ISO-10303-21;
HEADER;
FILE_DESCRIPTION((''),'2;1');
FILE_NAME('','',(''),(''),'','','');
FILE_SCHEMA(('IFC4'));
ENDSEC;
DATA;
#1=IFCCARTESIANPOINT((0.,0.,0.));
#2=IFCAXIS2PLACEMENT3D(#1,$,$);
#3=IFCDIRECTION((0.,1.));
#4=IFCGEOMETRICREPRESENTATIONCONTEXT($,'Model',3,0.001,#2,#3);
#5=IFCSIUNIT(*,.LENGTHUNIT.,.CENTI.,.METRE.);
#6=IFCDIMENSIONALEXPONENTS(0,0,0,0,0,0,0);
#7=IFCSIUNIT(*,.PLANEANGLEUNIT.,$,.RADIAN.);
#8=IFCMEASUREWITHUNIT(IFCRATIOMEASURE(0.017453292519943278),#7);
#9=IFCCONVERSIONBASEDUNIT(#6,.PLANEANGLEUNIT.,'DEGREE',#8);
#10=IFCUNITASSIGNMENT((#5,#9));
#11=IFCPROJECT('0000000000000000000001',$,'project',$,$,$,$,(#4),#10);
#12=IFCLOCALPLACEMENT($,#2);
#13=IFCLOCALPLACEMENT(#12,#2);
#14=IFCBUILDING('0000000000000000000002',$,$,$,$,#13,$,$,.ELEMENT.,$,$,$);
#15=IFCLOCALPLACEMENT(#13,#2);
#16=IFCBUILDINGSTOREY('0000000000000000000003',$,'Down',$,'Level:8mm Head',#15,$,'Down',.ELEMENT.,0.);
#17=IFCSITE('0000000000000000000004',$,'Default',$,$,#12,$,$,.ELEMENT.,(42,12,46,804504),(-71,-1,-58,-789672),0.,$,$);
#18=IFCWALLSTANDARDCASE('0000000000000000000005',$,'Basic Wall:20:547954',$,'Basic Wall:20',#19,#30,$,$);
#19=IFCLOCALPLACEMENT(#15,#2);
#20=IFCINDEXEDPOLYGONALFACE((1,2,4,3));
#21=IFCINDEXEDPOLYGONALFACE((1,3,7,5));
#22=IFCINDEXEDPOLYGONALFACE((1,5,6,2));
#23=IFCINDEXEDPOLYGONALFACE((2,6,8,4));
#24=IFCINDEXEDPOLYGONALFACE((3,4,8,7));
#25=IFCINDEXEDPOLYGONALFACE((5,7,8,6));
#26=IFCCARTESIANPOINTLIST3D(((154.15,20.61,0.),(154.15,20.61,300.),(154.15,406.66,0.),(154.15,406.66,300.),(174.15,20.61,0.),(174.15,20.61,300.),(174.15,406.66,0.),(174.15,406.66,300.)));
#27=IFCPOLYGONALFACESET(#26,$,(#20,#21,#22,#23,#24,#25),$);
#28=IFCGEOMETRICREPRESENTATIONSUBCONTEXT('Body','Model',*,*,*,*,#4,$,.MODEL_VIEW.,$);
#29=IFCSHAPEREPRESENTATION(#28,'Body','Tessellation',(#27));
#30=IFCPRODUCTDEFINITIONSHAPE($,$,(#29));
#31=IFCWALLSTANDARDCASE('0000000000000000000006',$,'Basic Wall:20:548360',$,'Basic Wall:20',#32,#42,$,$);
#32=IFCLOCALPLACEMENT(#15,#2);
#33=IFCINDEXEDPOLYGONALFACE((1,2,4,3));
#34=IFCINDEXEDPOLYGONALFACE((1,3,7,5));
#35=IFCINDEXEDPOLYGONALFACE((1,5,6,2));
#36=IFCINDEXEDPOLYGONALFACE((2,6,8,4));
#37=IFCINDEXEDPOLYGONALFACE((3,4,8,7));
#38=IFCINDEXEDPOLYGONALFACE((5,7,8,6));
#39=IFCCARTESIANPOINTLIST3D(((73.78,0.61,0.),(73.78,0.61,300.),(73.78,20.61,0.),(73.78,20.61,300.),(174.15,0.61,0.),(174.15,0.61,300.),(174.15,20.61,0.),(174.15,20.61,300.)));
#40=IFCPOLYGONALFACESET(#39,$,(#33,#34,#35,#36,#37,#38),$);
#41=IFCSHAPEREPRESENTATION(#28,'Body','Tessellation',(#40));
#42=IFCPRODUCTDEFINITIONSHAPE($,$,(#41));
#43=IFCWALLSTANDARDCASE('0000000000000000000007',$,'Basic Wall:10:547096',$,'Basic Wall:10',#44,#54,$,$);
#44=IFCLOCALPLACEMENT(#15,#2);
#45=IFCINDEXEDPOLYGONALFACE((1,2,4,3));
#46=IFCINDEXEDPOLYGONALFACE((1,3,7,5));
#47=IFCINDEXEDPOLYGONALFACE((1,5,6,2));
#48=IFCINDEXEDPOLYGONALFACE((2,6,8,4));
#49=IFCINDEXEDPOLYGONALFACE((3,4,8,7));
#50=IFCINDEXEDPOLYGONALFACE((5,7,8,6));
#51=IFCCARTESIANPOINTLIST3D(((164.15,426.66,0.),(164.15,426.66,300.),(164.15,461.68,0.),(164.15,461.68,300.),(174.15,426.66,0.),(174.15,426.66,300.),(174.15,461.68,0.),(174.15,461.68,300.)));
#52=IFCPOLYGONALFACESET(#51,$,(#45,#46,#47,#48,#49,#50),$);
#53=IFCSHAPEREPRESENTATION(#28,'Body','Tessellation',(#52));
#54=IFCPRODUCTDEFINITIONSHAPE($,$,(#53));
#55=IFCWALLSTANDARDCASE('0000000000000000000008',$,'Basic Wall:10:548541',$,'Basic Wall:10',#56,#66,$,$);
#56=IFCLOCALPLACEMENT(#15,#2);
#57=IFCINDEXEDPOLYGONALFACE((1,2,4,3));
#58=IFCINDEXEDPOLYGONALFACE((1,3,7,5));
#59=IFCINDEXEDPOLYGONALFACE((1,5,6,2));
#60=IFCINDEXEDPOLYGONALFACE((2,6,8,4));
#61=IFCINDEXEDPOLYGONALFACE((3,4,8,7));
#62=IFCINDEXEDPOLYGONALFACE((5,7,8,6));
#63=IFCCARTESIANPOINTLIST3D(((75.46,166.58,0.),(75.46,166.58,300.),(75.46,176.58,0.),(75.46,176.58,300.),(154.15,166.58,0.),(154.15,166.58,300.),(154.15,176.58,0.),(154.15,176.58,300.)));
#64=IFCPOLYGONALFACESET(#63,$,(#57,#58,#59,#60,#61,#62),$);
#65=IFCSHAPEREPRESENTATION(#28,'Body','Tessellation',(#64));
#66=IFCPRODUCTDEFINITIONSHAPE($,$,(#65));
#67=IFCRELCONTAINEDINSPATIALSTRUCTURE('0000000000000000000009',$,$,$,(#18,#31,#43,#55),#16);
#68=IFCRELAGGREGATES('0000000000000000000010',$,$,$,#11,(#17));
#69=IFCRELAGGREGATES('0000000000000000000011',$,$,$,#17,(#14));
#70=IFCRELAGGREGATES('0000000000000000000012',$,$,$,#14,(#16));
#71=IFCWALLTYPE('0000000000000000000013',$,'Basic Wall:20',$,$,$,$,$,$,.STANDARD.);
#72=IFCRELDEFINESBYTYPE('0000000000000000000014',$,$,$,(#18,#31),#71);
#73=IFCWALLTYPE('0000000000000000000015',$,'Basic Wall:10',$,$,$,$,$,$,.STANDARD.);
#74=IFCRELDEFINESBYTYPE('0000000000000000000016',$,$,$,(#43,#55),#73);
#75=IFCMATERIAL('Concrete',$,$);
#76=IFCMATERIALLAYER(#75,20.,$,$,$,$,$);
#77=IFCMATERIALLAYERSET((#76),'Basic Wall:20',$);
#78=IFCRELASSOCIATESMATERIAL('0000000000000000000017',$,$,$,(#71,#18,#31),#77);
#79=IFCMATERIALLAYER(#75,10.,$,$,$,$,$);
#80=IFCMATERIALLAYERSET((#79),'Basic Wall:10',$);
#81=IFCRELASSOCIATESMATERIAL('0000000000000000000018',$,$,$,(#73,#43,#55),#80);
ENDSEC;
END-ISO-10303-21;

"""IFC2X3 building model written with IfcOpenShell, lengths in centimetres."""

from ifc_helpers import new_model, entity, si_unit, converted_unit, direction, frame, frame_2d, origin, place, context, subcontext, project, spatial, rectangle, extrude, material, layer, layer_set, layer_usage, type_object, element, save


model = new_model("IFC2X3")

# Units and contexts
model_context = context("Model", 3, precision=0.001, world=origin(), true_north=direction((0.0, 1.0)))
body_context = subcontext(model_context, "Body", "Model", "MODEL_VIEW")
ifc_project = project(units=[si_unit("LENGTHUNIT", "METRE", prefix="CENTI"), converted_unit("PLANEANGLEUNIT", "DEGREE", entity("IfcRatioMeasure", 0.017453292519943278), si_unit("PLANEANGLEUNIT", "RADIAN"), dimensions=[0, 0, 0, 0, 0, 0, 0])], contexts=[model_context])

# Site, building, storey
site_placement = place(None, origin())
site = spatial("IfcSite", under=ifc_project, at=site_placement, Name="Default", CompositionType="ELEMENT", RefLatitude=(42, 12, 46, 804504), RefLongitude=(-71, -1, -58, -789672), RefElevation=0.0)
building_placement = place(site_placement, origin())
building = spatial("IfcBuilding", under=site, at=building_placement, CompositionType="ELEMENT")
storey_placement = place(building_placement, origin())
storey = spatial("IfcBuildingStorey", under=building, at=storey_placement, Name="Down", ObjectType="Level:8mm Head", LongName="Down", CompositionType="ELEMENT", Elevation=0.0)

# Shared definitions
ifc_material = material(Name="Concrete")

# Walls
ifc_layer_1 = layer(ifc_material, 20.0)
ifc_layer_set_1 = layer_set([ifc_layer_1], Name="Basic Wall:20")
wall_type_1 = type_object("IfcWallType", Name="Basic Wall:20", PredefinedType="STANDARD", material=ifc_layer_set_1)
ifc_layer_usage_1 = layer_usage(ifc_layer_set_1, "AXIS2", "NEGATIVE", 10.0)
wall_1_placement = place(storey_placement, frame((164.15, 406.66, 0.0), z_axis=(0.0, 0.0, 1.0), x_axis=(0.0, -1.0, 0.0)))
element("IfcWallStandardCase", 1, at=wall_1_placement, inside=storey, type_object=wall_type_1, material=ifc_layer_usage_1, Name="Basic Wall:20:547954", ObjectType="Basic Wall:20", context=body_context, shape_type="SweptSolid", body=[
    extrude(rectangle(XDim=386.06, YDim=20.0, at=frame_2d((193.03, 0.0), x_axis=(-1.0, 0.0))), origin(), (0.0, 0.0, 1.0), 300.0),
])
ifc_layer_usage_2 = layer_usage(ifc_layer_set_1, "AXIS2", "NEGATIVE", 10.0)
wall_2_placement = place(storey_placement, frame((174.15, 10.61, 0.0), z_axis=(0.0, 0.0, 1.0), x_axis=(-1.0, 0.0, 0.0)))
element("IfcWallStandardCase", 2, at=wall_2_placement, inside=storey, type_object=wall_type_1, material=ifc_layer_usage_2, Name="Basic Wall:20:548360", ObjectType="Basic Wall:20", context=body_context, shape_type="SweptSolid", body=[
    extrude(rectangle(XDim=100.36, YDim=20.0, at=frame_2d((50.18, 0.0), x_axis=(-1.0, 0.0))), origin(), (0.0, 0.0, 1.0), 300.0),
])
ifc_layer_2 = layer(ifc_material, 10.0)
ifc_layer_set_2 = layer_set([ifc_layer_2], Name="Basic Wall:10")
ifc_layer_usage_3 = layer_usage(ifc_layer_set_2, "AXIS2", "POSITIVE", -5.0)
wall_type_2 = type_object("IfcWallType", Name="Basic Wall:10", PredefinedType="STANDARD", material=ifc_layer_set_2)
wall_3_placement = place(storey_placement, frame((169.15, 426.66, 0.0), z_axis=(0.0, 0.0, 1.0), x_axis=(0.0, 1.0, 0.0)))
element("IfcWallStandardCase", 3, at=wall_3_placement, inside=storey, type_object=wall_type_2, material=ifc_layer_usage_3, Name="Basic Wall:10:547096", ObjectType="Basic Wall:10", context=body_context, shape_type="SweptSolid", body=[
    extrude(rectangle(XDim=35.01, YDim=10.0, at=frame_2d((17.51, 0.0), x_axis=(-1.0, 0.0))), origin(), (0.0, 0.0, 1.0), 300.0),
])
ifc_layer_usage_4 = layer_usage(ifc_layer_set_2, "AXIS2", "POSITIVE", -5.0)
wall_4_placement = place(storey_placement, frame((154.15, 171.58, 0.0), z_axis=(0.0, 0.0, 1.0), x_axis=(-1.0, 0.0, 0.0)))
element("IfcWallStandardCase", 4, at=wall_4_placement, inside=storey, type_object=wall_type_2, material=ifc_layer_usage_4, Name="Basic Wall:10:548541", ObjectType="Basic Wall:10", context=body_context, shape_type="SweptSolid", body=[
    extrude(rectangle(XDim=78.69, YDim=10.0, at=frame_2d((39.34, 0.0), x_axis=(-1.0, 0.0))), origin(), (0.0, 0.0, 1.0), 300.0),
])

save(model, "model.ifc")
